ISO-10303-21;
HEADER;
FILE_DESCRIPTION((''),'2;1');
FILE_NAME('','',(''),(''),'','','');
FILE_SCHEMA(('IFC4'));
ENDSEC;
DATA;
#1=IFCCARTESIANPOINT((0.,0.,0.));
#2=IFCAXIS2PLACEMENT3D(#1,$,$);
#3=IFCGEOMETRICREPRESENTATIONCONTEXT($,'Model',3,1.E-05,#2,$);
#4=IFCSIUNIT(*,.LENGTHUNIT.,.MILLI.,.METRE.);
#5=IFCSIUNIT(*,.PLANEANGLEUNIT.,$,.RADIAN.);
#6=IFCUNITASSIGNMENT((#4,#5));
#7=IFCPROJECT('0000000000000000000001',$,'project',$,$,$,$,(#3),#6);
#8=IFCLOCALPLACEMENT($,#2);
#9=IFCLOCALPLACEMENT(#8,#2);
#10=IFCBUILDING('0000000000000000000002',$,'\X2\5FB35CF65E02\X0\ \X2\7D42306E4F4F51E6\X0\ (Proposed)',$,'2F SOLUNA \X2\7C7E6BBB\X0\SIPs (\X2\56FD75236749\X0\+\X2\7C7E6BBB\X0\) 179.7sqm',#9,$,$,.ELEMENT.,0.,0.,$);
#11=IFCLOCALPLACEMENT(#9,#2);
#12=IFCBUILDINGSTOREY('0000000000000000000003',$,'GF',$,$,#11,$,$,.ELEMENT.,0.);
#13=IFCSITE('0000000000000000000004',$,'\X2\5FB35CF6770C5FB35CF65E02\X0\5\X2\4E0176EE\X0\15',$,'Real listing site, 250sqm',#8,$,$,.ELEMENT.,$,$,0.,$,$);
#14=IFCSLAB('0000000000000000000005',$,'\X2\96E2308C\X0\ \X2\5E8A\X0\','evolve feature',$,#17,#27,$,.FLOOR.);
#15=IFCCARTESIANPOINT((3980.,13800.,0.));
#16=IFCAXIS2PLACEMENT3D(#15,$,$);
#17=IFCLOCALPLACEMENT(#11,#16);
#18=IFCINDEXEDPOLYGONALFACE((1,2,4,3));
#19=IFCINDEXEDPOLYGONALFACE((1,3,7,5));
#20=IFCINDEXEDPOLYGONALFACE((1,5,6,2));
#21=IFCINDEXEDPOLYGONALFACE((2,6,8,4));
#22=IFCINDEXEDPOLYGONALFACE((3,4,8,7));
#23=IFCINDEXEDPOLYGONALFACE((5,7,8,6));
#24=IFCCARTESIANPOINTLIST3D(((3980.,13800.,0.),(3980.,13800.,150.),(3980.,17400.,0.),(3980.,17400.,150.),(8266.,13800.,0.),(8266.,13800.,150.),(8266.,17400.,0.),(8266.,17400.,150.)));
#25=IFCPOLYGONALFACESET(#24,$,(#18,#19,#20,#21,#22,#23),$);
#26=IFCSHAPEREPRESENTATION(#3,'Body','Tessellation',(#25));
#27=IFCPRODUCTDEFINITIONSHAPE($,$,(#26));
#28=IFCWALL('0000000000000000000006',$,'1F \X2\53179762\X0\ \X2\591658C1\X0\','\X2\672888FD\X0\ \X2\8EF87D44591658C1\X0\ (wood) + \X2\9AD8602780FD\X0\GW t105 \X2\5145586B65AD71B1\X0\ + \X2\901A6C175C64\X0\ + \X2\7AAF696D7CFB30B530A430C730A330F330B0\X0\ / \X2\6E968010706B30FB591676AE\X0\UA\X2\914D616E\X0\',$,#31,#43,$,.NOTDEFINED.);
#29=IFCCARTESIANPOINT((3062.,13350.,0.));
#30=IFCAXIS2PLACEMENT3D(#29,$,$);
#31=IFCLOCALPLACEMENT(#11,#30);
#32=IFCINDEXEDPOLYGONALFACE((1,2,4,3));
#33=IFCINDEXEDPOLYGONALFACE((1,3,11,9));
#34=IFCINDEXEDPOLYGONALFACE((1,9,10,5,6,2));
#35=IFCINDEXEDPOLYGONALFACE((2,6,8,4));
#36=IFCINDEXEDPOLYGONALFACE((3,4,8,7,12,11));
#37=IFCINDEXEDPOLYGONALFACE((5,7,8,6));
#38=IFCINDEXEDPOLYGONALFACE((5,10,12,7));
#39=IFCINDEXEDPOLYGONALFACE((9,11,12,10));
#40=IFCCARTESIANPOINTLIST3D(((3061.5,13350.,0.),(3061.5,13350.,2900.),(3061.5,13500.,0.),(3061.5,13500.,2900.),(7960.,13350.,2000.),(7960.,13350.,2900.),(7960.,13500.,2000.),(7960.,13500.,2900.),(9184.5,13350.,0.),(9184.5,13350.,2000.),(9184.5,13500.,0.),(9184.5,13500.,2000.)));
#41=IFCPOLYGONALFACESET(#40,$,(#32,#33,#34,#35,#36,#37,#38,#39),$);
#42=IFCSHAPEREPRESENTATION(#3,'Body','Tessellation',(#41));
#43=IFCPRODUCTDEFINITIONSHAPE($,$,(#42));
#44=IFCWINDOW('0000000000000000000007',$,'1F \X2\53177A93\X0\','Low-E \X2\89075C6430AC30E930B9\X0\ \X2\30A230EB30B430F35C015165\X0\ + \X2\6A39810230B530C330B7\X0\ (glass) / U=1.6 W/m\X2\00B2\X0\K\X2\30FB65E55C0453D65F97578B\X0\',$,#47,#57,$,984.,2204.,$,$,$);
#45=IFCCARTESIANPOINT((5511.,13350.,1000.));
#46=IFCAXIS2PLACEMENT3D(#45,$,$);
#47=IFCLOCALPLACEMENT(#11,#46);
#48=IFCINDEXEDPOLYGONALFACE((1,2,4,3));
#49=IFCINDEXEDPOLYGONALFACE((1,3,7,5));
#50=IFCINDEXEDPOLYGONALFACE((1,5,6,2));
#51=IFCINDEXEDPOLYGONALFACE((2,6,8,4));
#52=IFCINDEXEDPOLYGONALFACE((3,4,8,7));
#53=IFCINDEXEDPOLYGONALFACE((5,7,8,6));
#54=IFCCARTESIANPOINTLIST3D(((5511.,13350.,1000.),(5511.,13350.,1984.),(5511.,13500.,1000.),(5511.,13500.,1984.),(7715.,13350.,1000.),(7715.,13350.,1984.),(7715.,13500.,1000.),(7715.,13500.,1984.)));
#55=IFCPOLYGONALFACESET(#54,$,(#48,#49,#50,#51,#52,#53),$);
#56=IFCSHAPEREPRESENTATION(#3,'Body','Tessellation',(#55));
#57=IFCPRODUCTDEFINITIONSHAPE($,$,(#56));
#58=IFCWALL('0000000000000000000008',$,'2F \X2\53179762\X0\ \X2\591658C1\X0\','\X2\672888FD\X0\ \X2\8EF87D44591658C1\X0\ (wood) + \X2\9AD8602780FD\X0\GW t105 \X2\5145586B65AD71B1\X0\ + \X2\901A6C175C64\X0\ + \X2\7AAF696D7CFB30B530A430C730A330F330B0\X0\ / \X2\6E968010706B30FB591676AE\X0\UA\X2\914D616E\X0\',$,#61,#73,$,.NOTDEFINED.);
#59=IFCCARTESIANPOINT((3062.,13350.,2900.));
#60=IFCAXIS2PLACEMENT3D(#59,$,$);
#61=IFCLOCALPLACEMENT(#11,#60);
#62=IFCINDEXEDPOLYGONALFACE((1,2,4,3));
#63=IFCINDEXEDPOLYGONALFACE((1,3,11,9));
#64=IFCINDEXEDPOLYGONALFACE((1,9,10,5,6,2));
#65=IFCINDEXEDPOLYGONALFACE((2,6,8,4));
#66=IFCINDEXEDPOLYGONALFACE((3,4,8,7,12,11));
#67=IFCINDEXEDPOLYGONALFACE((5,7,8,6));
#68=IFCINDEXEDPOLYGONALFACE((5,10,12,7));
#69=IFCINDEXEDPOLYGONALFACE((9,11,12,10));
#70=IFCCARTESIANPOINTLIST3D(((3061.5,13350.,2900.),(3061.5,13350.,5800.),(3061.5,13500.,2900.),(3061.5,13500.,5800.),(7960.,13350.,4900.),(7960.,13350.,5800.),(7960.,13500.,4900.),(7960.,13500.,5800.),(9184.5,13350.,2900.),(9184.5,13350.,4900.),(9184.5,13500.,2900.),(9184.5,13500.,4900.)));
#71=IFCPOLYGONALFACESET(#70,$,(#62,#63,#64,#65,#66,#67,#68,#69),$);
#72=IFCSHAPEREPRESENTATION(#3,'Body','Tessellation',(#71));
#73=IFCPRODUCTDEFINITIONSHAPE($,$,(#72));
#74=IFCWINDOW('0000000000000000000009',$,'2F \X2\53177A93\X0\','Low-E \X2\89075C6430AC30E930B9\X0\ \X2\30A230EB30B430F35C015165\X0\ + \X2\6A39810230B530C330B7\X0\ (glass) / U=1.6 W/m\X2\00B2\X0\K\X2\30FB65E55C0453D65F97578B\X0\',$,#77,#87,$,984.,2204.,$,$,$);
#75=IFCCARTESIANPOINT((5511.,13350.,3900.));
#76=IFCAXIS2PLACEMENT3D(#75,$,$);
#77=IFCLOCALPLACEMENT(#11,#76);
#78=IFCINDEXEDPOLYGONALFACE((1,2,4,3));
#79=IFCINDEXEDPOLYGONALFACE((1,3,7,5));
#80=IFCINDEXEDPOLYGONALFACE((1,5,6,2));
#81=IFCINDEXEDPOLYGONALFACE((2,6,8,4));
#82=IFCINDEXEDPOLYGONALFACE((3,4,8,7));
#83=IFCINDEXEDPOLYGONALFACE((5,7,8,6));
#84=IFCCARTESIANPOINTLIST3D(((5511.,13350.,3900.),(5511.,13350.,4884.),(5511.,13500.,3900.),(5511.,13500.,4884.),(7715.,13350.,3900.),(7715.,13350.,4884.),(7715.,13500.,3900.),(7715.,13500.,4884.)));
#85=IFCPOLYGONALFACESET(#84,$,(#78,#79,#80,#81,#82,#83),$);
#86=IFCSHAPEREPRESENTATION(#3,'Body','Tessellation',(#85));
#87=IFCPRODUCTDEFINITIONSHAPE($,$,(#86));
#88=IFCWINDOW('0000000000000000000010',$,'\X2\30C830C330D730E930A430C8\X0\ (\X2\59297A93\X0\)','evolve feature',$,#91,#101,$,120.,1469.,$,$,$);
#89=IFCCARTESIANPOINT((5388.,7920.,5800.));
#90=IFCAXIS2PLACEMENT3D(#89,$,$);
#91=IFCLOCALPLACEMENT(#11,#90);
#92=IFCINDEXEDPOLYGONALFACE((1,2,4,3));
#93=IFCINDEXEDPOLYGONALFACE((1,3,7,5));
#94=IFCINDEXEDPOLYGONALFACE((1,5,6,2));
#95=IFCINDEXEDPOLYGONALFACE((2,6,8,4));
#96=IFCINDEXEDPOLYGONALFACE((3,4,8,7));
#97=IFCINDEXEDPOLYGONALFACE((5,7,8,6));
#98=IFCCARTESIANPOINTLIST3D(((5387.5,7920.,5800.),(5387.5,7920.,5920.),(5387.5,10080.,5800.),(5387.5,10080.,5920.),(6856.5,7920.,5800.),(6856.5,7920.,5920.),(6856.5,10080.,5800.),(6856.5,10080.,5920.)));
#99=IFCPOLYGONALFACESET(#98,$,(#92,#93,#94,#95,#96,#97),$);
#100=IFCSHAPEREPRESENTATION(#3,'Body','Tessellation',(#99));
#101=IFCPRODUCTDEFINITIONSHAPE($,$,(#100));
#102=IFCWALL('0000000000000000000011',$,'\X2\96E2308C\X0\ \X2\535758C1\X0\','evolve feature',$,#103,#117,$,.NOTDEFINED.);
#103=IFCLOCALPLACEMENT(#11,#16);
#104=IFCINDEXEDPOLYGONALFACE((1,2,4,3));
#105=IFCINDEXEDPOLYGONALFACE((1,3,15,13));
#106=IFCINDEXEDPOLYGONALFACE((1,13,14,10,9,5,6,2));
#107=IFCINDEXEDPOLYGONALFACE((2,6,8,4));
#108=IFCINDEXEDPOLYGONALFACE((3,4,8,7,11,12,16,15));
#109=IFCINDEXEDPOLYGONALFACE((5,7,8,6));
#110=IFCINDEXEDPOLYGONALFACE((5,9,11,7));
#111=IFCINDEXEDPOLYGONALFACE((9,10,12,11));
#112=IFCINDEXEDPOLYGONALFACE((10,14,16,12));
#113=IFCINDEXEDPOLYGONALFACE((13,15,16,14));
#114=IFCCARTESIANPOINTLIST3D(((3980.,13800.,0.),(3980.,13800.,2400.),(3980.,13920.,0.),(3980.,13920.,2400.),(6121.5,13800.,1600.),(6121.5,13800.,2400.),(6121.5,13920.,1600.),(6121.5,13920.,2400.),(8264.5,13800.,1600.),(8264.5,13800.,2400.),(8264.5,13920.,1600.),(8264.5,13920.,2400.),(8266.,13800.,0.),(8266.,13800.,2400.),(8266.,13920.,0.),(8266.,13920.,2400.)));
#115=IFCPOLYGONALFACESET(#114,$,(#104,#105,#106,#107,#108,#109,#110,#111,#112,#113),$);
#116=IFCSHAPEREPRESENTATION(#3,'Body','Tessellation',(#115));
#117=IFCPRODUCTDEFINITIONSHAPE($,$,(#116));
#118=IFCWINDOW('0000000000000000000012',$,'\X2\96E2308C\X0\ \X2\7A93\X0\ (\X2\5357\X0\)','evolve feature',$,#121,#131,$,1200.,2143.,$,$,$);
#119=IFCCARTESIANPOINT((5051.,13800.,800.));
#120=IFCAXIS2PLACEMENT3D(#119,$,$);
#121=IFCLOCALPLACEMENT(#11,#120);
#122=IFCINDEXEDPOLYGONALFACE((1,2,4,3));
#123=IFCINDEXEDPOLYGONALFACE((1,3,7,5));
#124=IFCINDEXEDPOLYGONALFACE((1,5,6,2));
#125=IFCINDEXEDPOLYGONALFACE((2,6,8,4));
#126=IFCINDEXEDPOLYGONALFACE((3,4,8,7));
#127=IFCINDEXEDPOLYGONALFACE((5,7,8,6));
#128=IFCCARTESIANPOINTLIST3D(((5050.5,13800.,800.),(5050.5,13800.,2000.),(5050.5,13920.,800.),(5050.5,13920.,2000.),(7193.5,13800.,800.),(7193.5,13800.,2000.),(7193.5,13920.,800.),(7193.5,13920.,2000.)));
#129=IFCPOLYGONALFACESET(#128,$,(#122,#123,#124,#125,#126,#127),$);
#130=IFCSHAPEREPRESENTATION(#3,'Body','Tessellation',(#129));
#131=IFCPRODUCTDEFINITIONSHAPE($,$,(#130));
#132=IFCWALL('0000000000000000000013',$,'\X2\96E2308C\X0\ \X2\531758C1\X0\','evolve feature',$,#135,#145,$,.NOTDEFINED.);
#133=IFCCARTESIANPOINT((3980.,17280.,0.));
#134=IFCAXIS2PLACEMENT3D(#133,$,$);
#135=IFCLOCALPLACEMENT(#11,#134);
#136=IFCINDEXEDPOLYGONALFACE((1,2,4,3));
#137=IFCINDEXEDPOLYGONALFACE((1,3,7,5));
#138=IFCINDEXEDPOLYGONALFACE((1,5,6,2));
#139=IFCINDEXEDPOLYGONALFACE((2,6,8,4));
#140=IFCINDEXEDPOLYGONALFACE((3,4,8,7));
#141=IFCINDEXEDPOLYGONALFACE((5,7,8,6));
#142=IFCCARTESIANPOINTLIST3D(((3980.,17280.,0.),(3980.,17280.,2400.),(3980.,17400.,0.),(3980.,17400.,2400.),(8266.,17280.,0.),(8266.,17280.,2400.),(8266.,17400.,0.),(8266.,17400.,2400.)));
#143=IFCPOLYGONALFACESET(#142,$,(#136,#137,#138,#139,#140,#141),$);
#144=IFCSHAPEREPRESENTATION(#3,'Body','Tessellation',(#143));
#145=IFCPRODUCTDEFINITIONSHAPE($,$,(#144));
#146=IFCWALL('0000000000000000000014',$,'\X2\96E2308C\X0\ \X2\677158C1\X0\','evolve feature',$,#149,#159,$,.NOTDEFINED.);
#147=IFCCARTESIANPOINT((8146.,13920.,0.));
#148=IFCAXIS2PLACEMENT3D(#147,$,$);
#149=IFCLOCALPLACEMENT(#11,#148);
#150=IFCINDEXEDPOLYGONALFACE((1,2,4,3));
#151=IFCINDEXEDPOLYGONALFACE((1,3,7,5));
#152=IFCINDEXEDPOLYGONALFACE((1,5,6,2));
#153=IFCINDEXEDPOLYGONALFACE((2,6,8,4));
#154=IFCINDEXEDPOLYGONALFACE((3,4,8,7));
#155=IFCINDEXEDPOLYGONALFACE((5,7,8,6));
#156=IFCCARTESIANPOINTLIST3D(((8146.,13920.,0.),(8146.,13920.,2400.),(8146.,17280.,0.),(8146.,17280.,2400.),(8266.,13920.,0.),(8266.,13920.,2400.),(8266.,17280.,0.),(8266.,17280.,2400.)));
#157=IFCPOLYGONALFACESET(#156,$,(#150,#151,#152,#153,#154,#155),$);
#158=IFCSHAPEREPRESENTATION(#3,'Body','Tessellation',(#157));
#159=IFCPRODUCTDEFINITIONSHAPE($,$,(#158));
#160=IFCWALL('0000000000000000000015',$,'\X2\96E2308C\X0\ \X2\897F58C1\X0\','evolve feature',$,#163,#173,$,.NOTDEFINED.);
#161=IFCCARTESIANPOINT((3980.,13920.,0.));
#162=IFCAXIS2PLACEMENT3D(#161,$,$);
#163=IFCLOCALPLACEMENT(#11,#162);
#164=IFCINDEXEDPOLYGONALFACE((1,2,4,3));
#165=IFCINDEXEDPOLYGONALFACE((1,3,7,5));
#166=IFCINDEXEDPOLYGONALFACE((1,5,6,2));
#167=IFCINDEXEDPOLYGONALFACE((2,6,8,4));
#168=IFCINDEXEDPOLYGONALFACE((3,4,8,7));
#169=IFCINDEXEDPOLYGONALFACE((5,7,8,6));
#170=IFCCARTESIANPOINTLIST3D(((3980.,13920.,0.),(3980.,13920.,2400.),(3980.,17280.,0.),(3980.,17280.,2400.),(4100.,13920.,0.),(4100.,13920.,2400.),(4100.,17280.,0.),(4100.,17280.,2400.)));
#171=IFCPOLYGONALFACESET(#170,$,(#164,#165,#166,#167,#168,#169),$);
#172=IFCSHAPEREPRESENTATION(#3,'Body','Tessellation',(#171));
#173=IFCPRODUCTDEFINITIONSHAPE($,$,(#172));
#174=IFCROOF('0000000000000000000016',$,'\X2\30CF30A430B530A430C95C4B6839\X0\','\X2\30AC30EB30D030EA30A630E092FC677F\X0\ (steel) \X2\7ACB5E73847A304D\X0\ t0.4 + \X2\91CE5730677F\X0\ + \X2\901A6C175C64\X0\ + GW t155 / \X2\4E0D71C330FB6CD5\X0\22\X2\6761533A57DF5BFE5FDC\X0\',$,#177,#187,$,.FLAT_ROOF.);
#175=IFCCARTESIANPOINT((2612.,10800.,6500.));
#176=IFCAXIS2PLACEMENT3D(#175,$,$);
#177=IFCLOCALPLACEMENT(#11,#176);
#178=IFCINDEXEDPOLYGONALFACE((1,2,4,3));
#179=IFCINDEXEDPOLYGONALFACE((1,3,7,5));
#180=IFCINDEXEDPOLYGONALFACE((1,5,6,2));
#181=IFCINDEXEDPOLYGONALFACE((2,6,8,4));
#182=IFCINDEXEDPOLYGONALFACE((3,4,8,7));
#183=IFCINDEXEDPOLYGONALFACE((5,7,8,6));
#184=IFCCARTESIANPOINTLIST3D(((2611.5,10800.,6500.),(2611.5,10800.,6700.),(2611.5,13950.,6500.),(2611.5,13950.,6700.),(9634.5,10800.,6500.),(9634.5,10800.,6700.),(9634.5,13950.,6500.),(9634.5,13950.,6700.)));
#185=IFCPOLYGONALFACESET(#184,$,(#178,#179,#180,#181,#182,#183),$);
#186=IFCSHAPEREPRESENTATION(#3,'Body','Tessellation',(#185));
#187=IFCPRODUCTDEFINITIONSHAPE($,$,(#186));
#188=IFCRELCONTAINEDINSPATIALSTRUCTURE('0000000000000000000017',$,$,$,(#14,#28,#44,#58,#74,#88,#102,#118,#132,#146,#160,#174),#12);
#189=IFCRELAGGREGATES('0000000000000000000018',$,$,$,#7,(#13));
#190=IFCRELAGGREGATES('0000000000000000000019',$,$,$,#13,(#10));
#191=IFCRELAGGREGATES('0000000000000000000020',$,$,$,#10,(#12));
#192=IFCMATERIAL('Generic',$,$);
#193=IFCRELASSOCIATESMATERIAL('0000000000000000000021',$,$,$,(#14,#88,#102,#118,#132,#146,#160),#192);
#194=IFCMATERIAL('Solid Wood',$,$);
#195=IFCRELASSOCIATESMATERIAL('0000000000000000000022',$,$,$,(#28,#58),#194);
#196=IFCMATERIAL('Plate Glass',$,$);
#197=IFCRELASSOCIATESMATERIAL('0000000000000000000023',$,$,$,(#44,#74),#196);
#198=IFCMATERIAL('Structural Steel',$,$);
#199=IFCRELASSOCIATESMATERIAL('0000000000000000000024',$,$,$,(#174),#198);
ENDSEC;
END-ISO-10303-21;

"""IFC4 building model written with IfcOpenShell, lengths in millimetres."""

from ifc_helpers import new_model, si_unit, frame, frame_2d, origin, place, context, project, spatial, rectangle, extrude, material, element, fill, save


model = new_model("IFC4")

# Units and contexts
model_context = context("Model", 3, precision=1e-05, world=origin())
ifc_project = project(units=[si_unit("LENGTHUNIT", "METRE", prefix="MILLI"), si_unit("PLANEANGLEUNIT", "RADIAN")], contexts=[model_context])

# Site, building, storey
site_placement = place(None, origin())
site = spatial("IfcSite", under=ifc_project, at=site_placement, Name="徳島県徳島市5丁目15", ObjectType="Real listing site, 250sqm", CompositionType="ELEMENT", RefElevation=0.0)
building_placement = place(site_placement, origin())
building = spatial("IfcBuilding", under=site, at=building_placement, Name="徳島市 終の住処 (Proposed)", ObjectType="2F SOLUNA 籾殻SIPs (国産杉+籾殻) 179.7sqm", CompositionType="ELEMENT", ElevationOfRefHeight=0.0, ElevationOfTerrain=0.0)
storey_placement = place(building_placement, origin())
storey = spatial("IfcBuildingStorey", under=building, at=storey_placement, Name="GF", CompositionType="ELEMENT", Elevation=0.0)

# Slab
ifc_material_1 = material(Name="Generic")
slab_placement = place(storey_placement, frame((3980.0, 13800.0, 0.0)))
element("IfcSlab", 1, at=slab_placement, inside=storey, material=ifc_material_1, Name="離れ 床", Description="evolve feature", PredefinedType="FLOOR", context=model_context, shape_type="SweptSolid", body=[
    extrude(rectangle(XDim=4286.0, YDim=3600.0, at=frame_2d((2143.0, 1800.0))), frame((3980.0, 13800.0, 0.0)), (0.0, 0.0, 1.0), 150.0),
])

# Wall, opening, window
ifc_material_2 = material(Name="Solid Wood")
wall_1_placement = place(storey_placement, frame((3062.0, 13350.0, 0.0)))
wall_1 = element("IfcWall", 2, at=wall_1_placement, inside=storey, material=ifc_material_2, Name="1F 北面 外壁", Description="木製 軸組外壁 (wood) + 高性能GW t105 充填断熱 + 通気層 + 窯業系サイディング / 準耐火・外皮UA配慮", PredefinedType="NOTDEFINED", context=model_context, shape_type="SweptSolid", body=[
    extrude(rectangle(XDim=6123.0, YDim=150.0, at=frame_2d((3061.0, 75.0))), frame((3062.0, 13350.0, 0.0)), (0.0, 0.0, 1.0), 2900.0),
])
opening_1_placement = place(storey_placement, frame((5511.0, 13350.0, 1000.0)))
opening_1 = element("IfcOpeningElement", 3, at=opening_1_placement, cuts=wall_1, PredefinedType="NOTDEFINED", context=model_context, shape_type="SweptSolid", body=[
    extrude(rectangle(XDim=2204.0, YDim=150.0, at=frame_2d((1102.0, 75.0))), frame((5511.0, 13350.0, 1000.0)), (0.0, 0.0, 1.0), 984.0),
])
ifc_material_3 = material(Name="Plate Glass")
window_1_placement = place(storey_placement, frame((5511.0, 13350.0, 1000.0)))
window_1 = element("IfcWindow", 4, at=window_1_placement, inside=storey, material=ifc_material_3, Name="1F 北窓", Description="Low-E 複層ガラス アルゴン封入 + 樹脂サッシ (glass) / U=1.6 W/m²K・日射取得型", OverallHeight=984.0, OverallWidth=2204.0, context=model_context, shape_type="SweptSolid", body=[
    extrude(rectangle(XDim=2204.0, YDim=150.0, at=frame_2d((1102.0, 75.0))), frame((5511.0, 13350.0, 1000.0)), (0.0, 0.0, 1.0), 984.0),
])
fill(opening_1, window_1)

# Wall, opening, window
wall_2_placement = place(storey_placement, frame((3062.0, 13350.0, 2900.0)))
wall_2 = element("IfcWall", 5, at=wall_2_placement, inside=storey, material=ifc_material_2, Name="2F 北面 外壁", Description="木製 軸組外壁 (wood) + 高性能GW t105 充填断熱 + 通気層 + 窯業系サイディング / 準耐火・外皮UA配慮", PredefinedType="NOTDEFINED", context=model_context, shape_type="SweptSolid", body=[
    extrude(rectangle(XDim=6123.0, YDim=150.0, at=frame_2d((3061.0, 75.0))), frame((3062.0, 13350.0, 2900.0)), (0.0, 0.0, 1.0), 2900.0),
])
opening_2_placement = place(storey_placement, frame((5511.0, 13350.0, 3900.0)))
opening_2 = element("IfcOpeningElement", 6, at=opening_2_placement, cuts=wall_2, PredefinedType="NOTDEFINED", context=model_context, shape_type="SweptSolid", body=[
    extrude(rectangle(XDim=2204.0, YDim=150.0, at=frame_2d((1102.0, 75.0))), frame((5511.0, 13350.0, 3900.0)), (0.0, 0.0, 1.0), 984.0),
])
window_2_placement = place(storey_placement, frame((5511.0, 13350.0, 3900.0)))
window_2 = element("IfcWindow", 7, at=window_2_placement, inside=storey, material=ifc_material_3, Name="2F 北窓", Description="Low-E 複層ガラス アルゴン封入 + 樹脂サッシ (glass) / U=1.6 W/m²K・日射取得型", OverallHeight=984.0, OverallWidth=2204.0, context=model_context, shape_type="SweptSolid", body=[
    extrude(rectangle(XDim=2204.0, YDim=150.0, at=frame_2d((1102.0, 75.0))), frame((5511.0, 13350.0, 3900.0)), (0.0, 0.0, 1.0), 984.0),
])
fill(opening_2, window_2)

# Window
window_3_placement = place(storey_placement, frame((5388.0, 7920.0, 5800.0)))
element("IfcWindow", 8, at=window_3_placement, inside=storey, material=ifc_material_1, Name="トップライト (天窓)", Description="evolve feature", OverallHeight=120.0, OverallWidth=1469.0, context=model_context, shape_type="SweptSolid", body=[
    extrude(rectangle(XDim=1469.0, YDim=2160.0, at=frame_2d((734.0, 1080.0))), frame((5388.0, 7920.0, 5800.0)), (0.0, 0.0, 1.0), 120.0),
])

# Wall, opening, window
wall_3_placement = place(storey_placement, frame((3980.0, 13800.0, 0.0)))
wall_3 = element("IfcWall", 9, at=wall_3_placement, inside=storey, material=ifc_material_1, Name="離れ 南壁", Description="evolve feature", PredefinedType="NOTDEFINED", context=model_context, shape_type="SweptSolid", body=[
    extrude(rectangle(XDim=4286.0, YDim=120.0, at=frame_2d((2143.0, 60.0))), frame((3980.0, 13800.0, 0.0)), (0.0, 0.0, 1.0), 2400.0),
])
opening_3_placement = place(storey_placement, frame((5051.0, 13800.0, 800.0)))
opening_3 = element("IfcOpeningElement", 10, at=opening_3_placement, cuts=wall_3, PredefinedType="NOTDEFINED", context=model_context, shape_type="SweptSolid", body=[
    extrude(rectangle(XDim=2143.0, YDim=120.0, at=frame_2d((1071.0, 60.0))), frame((5051.0, 13800.0, 800.0)), (0.0, 0.0, 1.0), 1200.0),
])
window_4_placement = place(storey_placement, frame((5051.0, 13800.0, 800.0)))
window_4 = element("IfcWindow", 11, at=window_4_placement, inside=storey, material=ifc_material_1, Name="離れ 窓 (南)", Description="evolve feature", OverallHeight=1200.0, OverallWidth=2143.0, context=model_context, shape_type="SweptSolid", body=[
    extrude(rectangle(XDim=2143.0, YDim=120.0, at=frame_2d((1071.0, 60.0))), frame((5051.0, 13800.0, 800.0)), (0.0, 0.0, 1.0), 1200.0),
])
fill(opening_3, window_4)

# Walls
wall_4_placement = place(storey_placement, frame((3980.0, 17280.0, 0.0)))
element("IfcWall", 12, at=wall_4_placement, inside=storey, material=ifc_material_1, Name="離れ 北壁", Description="evolve feature", PredefinedType="NOTDEFINED", context=model_context, shape_type="SweptSolid", body=[
    extrude(rectangle(XDim=4286.0, YDim=120.0, at=frame_2d((2143.0, 60.0))), frame((3980.0, 17280.0, 0.0)), (0.0, 0.0, 1.0), 2400.0),
])
wall_5_placement = place(storey_placement, frame((8146.0, 13920.0, 0.0)))
element("IfcWall", 13, at=wall_5_placement, inside=storey, material=ifc_material_1, Name="離れ 東壁", Description="evolve feature", PredefinedType="NOTDEFINED", context=model_context, shape_type="SweptSolid", body=[
    extrude(rectangle(XDim=120.0, YDim=3360.0, at=frame_2d((60.0, 1680.0))), frame((8146.0, 13920.0, 0.0)), (0.0, 0.0, 1.0), 2400.0),
])
wall_6_placement = place(storey_placement, frame((3980.0, 13920.0, 0.0)))
element("IfcWall", 14, at=wall_6_placement, inside=storey, material=ifc_material_1, Name="離れ 西壁", Description="evolve feature", PredefinedType="NOTDEFINED", context=model_context, shape_type="SweptSolid", body=[
    extrude(rectangle(XDim=120.0, YDim=3360.0, at=frame_2d((60.0, 1680.0))), frame((3980.0, 13920.0, 0.0)), (0.0, 0.0, 1.0), 2400.0),
])

# Roof
ifc_material_4 = material(Name="Structural Steel")
roof_1_placement = place(storey_placement, frame((2612.0, 10800.0, 6500.0)))
element("IfcRoof", 15, at=roof_1_placement, inside=storey, material=ifc_material_4, Name="ハイサイド屋根", Description="ガルバリウム鋼板 (steel) 立平葺き t0.4 + 野地板 + 通気層 + GW t155 / 不燃・法22条区域対応", PredefinedType="FLAT_ROOF", context=model_context, shape_type="SweptSolid", body=[
    extrude(rectangle(XDim=7023.0, YDim=3150.0, at=frame_2d((3511.0, 1575.0))), frame((2612.0, 10800.0, 6500.0)), (0.0, 0.0, 1.0), 200.0),
])

save(model, "model.ifc")
